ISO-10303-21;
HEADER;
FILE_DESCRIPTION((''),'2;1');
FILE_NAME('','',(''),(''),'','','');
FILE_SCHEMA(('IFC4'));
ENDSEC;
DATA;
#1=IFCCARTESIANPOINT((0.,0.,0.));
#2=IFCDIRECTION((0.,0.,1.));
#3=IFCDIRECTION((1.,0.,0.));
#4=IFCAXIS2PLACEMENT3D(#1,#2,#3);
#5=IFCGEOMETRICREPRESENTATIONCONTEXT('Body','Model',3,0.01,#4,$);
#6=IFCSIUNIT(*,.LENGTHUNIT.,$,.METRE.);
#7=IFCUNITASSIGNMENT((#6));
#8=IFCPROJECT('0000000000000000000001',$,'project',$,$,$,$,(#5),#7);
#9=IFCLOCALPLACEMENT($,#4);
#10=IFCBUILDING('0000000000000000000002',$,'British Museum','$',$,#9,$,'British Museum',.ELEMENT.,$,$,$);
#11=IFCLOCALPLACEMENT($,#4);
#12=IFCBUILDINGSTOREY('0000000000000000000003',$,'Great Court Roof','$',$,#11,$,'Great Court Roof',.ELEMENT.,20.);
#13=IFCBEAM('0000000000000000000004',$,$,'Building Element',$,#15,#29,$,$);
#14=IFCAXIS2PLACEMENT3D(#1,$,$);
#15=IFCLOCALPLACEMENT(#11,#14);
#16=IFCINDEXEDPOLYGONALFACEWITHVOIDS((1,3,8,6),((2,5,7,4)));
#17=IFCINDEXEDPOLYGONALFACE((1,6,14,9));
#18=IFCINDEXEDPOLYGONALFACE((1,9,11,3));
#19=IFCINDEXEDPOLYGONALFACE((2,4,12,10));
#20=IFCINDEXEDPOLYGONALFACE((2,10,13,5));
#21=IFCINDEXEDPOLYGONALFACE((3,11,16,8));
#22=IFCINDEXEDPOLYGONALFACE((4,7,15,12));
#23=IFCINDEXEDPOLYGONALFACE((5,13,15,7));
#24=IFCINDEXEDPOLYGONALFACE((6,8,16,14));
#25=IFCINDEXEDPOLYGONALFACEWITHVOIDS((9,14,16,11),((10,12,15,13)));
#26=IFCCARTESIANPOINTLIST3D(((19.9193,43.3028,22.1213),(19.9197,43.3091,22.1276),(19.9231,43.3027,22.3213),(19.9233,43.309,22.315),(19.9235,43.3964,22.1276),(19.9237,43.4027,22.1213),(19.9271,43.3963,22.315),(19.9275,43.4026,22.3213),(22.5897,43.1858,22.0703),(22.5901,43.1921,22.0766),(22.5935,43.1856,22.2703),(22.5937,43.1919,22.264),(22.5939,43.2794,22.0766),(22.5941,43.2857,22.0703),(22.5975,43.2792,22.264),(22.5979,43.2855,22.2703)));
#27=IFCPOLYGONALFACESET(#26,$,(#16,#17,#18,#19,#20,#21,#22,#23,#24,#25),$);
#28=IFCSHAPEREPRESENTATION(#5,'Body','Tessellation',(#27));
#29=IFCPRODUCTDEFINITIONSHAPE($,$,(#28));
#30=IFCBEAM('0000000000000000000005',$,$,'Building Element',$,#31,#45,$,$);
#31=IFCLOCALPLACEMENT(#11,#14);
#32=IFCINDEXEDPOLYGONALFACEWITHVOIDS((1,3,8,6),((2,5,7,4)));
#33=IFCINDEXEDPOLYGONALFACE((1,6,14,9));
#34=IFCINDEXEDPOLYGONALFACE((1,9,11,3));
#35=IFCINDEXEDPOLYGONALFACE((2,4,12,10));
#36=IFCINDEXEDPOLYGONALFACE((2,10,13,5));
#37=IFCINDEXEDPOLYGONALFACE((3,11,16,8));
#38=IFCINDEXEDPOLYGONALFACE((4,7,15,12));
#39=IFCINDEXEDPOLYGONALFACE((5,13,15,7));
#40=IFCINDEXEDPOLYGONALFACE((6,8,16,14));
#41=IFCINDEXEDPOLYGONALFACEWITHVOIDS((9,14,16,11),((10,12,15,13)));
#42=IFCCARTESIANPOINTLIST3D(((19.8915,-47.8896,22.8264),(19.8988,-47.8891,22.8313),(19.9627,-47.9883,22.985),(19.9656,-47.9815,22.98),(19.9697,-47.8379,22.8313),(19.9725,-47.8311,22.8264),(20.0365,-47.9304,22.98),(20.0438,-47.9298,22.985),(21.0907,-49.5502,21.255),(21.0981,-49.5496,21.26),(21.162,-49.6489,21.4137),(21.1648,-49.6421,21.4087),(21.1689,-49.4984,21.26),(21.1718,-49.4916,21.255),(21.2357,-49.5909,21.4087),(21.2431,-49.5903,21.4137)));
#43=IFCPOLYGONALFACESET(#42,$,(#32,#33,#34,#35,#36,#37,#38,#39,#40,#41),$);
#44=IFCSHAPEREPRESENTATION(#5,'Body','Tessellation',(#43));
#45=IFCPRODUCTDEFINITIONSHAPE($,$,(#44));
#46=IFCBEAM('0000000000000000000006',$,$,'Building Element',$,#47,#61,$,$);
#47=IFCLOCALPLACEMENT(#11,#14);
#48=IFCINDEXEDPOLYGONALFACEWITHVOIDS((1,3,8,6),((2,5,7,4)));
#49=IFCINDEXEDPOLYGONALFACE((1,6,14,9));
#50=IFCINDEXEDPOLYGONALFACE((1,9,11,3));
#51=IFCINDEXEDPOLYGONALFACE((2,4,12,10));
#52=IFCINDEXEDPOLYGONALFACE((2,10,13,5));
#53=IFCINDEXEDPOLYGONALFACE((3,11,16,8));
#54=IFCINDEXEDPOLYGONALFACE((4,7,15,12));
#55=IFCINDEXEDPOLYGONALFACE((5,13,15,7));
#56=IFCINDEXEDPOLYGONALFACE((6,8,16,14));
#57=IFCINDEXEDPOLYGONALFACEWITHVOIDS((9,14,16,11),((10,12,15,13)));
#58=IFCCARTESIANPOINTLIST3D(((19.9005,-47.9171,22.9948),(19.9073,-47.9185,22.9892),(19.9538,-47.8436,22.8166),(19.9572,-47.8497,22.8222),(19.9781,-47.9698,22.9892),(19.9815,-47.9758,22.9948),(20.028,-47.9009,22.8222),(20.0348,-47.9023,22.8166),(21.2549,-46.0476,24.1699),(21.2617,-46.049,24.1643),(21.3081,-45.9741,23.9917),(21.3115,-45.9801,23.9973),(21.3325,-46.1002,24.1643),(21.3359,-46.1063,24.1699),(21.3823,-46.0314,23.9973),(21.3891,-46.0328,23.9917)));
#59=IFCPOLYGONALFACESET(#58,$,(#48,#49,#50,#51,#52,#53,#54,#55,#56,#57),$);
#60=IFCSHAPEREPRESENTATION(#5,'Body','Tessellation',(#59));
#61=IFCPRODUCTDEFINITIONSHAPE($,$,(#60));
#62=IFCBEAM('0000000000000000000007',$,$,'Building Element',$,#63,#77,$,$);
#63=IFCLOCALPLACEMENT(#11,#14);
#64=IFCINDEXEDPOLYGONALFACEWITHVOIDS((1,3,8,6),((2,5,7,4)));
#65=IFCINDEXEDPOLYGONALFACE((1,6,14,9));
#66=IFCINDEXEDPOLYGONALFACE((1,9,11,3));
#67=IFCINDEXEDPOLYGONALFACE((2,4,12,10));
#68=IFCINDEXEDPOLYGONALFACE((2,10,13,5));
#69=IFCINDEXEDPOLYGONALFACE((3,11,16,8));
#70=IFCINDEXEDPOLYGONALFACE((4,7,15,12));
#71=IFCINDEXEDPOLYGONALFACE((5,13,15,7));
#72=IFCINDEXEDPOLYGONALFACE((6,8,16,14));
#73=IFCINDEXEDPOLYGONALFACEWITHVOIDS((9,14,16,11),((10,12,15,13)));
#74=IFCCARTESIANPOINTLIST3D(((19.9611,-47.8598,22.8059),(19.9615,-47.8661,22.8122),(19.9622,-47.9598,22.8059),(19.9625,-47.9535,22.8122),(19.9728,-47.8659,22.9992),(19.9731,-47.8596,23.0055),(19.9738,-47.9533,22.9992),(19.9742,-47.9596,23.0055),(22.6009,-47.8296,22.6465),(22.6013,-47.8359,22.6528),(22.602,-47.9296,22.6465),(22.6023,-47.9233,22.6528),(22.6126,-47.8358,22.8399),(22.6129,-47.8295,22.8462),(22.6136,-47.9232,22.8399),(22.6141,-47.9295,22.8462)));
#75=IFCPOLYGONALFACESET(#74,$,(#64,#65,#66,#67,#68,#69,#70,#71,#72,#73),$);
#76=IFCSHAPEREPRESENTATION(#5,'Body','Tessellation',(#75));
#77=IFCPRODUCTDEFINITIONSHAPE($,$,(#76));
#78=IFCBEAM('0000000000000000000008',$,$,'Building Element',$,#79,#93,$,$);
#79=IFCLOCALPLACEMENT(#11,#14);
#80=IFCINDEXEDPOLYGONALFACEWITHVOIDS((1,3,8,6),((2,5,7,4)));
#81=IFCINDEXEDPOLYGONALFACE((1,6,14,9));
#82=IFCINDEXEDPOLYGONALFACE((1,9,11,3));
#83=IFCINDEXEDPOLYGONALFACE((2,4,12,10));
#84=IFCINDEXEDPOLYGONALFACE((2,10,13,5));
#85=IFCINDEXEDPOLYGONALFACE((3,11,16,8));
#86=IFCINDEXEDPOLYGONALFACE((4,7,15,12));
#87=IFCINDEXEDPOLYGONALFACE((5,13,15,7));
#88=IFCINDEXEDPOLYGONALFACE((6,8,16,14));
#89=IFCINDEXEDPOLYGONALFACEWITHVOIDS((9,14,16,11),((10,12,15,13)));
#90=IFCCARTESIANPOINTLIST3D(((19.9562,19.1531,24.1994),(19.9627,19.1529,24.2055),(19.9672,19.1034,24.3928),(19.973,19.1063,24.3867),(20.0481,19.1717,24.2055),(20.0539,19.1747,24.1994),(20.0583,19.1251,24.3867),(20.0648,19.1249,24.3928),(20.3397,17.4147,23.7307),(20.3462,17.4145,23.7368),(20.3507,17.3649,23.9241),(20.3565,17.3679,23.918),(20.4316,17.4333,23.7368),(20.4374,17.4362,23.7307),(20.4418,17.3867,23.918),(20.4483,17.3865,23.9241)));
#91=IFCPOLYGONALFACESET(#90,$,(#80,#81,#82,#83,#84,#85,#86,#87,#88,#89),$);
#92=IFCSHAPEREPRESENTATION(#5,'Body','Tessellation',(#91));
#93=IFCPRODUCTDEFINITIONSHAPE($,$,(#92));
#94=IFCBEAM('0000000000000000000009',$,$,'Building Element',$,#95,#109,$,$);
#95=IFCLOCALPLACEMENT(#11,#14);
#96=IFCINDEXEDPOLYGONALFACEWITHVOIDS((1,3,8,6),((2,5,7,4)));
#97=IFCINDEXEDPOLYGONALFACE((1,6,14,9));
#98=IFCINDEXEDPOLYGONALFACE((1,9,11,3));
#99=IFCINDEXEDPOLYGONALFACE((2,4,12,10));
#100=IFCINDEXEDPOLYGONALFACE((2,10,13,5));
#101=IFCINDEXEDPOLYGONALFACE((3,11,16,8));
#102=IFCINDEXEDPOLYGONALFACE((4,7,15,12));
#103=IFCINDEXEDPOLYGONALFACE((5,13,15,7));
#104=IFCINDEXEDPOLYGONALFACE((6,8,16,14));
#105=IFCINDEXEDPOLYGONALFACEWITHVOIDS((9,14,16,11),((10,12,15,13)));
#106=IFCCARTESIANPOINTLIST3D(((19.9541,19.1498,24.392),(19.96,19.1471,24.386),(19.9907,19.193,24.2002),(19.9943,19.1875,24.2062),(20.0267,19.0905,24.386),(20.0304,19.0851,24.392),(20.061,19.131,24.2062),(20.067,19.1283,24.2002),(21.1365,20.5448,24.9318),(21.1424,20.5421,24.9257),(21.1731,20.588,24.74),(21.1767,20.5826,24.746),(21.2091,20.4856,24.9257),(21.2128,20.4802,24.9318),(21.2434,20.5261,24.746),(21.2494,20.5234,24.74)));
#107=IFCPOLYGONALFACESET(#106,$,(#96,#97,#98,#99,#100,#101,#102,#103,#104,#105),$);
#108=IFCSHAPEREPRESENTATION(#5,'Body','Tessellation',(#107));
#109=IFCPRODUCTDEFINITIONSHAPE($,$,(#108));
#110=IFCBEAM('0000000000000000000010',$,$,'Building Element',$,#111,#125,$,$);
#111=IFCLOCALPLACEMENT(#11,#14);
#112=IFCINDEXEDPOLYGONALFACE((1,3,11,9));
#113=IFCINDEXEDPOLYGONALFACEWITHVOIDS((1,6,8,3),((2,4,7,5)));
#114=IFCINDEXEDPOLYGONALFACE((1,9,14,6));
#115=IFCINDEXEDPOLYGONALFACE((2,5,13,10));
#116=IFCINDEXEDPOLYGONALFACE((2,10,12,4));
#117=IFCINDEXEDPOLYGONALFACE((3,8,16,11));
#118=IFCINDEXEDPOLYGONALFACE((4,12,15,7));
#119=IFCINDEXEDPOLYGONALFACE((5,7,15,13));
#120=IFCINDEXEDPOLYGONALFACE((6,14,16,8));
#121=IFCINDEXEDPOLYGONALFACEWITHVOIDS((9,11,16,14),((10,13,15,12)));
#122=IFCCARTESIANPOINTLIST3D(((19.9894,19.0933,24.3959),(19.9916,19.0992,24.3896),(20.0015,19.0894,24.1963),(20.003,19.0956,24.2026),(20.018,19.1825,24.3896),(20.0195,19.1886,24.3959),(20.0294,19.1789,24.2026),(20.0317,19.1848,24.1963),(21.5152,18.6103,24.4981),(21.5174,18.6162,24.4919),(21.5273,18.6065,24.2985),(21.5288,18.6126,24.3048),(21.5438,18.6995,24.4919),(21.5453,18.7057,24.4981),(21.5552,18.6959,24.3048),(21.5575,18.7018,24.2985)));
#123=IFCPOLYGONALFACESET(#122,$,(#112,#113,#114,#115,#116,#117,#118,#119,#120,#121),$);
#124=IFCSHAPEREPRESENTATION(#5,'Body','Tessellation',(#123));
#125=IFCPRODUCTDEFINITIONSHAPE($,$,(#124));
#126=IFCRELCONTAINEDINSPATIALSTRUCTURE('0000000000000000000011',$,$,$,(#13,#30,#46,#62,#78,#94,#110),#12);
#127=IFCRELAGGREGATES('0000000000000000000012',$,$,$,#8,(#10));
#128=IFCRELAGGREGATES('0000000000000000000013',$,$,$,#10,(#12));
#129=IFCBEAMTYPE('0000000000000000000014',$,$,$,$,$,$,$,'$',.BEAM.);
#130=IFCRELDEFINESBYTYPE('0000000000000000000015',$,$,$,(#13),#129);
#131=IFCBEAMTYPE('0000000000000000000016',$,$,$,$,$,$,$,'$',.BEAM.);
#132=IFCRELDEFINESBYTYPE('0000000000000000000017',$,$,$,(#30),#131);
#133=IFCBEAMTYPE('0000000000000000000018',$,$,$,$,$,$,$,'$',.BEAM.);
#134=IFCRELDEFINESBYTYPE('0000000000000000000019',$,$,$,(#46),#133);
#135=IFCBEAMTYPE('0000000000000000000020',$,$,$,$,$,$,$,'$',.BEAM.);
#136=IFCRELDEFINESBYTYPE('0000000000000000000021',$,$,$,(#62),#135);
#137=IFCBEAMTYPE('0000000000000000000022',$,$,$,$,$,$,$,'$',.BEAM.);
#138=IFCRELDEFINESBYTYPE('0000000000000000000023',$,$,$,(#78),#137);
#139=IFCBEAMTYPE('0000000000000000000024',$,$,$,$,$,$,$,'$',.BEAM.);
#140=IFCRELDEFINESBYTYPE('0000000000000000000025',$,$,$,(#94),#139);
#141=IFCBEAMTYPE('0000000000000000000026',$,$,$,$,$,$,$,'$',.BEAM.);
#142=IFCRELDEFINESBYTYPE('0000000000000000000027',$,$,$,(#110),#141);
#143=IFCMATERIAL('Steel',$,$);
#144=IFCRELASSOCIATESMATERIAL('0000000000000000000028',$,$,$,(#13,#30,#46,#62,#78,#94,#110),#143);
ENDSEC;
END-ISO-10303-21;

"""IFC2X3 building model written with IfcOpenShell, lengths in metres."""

from ifc_helpers import new_model, si_unit, frame, origin_with_axes, origin_2d, place, context, project, spatial, hollow_rectangle, extrude, material, type_object, element, save


model = new_model("IFC2X3")

# Units and contexts
model_context = context("Model", 3, precision=0.01, world=origin_with_axes(), identifier="Body")
ifc_project = project(units=[si_unit("LENGTHUNIT", "METRE")], contexts=[model_context])

# Building, storey
building_placement = place(None, origin_with_axes())
building = spatial("IfcBuilding", under=ifc_project, at=building_placement, Name="British Museum", Description="$", LongName="British Museum", CompositionType="ELEMENT")
storey_placement = place(None, origin_with_axes())
storey = spatial("IfcBuildingStorey", under=building, at=storey_placement, Name="Great Court Roof", Description="$", LongName="Great Court Roof", CompositionType="ELEMENT", Elevation=20.0)

# Beams
ifc_material = material(Name="Steel")
beam_type_1 = type_object("IfcBeamType", ElementType="$", PredefinedType="BEAM")
beam_1_placement = place(None, origin_with_axes())
element("IfcBeam", 1, at=beam_1_placement, inside=storey, type_object=beam_type_1, material=ifc_material, Description="Building Element", context=model_context, shape_type="SweptSolid", body=[
    extrude(hollow_rectangle(XDim=0.1, YDim=0.2, WallThickness=0.0063, InnerFilletRadius=-0.0063, OuterFilletRadius=0.0, at=origin_2d()), frame((19.9234, 43.3527, 22.2213), z_axis=(0.998859, -0.043783, -0.019081), x_axis=(0.043791, 0.999041, 0.0)), (0.0, 0.0, 1.0), 2.6735),
])
beam_type_2 = type_object("IfcBeamType", ElementType="$", PredefinedType="BEAM")
beam_2_placement = place(None, origin_with_axes())
element("IfcBeam", 2, at=beam_2_placement, inside=storey, type_object=beam_type_2, material=ifc_material, Description="Building Element", context=model_context, shape_type="SweptSolid", body=[
    extrude(hollow_rectangle(XDim=0.1, YDim=0.2, WallThickness=0.0063, InnerFilletRadius=-0.0063, OuterFilletRadius=0.0, at=origin_2d()), frame((19.9676, -47.9097, 22.9057), z_axis=(0.464529, -0.643211, -0.608681), x_axis=(0.810687, 0.58548, 0.0)), (0.0, 0.0, 1.0), 2.5816),
])
beam_type_3 = type_object("IfcBeamType", ElementType="$", PredefinedType="BEAM")
beam_3_placement = place(None, origin_with_axes())
element("IfcBeam", 3, at=beam_3_placement, inside=storey, type_object=beam_type_3, material=ifc_material, Description="Building Element", context=model_context, shape_type="SweptSolid", body=[
    extrude(hollow_rectangle(XDim=0.1, YDim=0.2, WallThickness=0.0063, InnerFilletRadius=-0.0063, OuterFilletRadius=0.0, at=origin_2d()), frame((19.9676, -47.9097, 22.9057), z_axis=(0.522834, 0.721709, 0.45363), x_axis=(-0.809826, 0.58667, 0.0)), (0.0, 0.0, 1.0), 2.5904),
])
beam_type_4 = type_object("IfcBeamType", ElementType="$", PredefinedType="BEAM")
beam_4_placement = place(None, origin_with_axes())
element("IfcBeam", 4, at=beam_4_placement, inside=storey, type_object=beam_type_4, material=ifc_material, Description="Building Element", context=model_context, shape_type="SweptSolid", body=[
    extrude(hollow_rectangle(XDim=0.1, YDim=0.2, WallThickness=0.0063, InnerFilletRadius=-0.0063, OuterFilletRadius=0.0, at=origin_2d()), frame((19.9676, -47.9097, 22.9057), z_axis=(0.998118, 0.011408, -0.060249), x_axis=(-0.011428, 0.999935, 0.0)), (0.0, 0.0, 1.0), 2.6448),
])
beam_type_5 = type_object("IfcBeamType", ElementType="$", PredefinedType="BEAM")
beam_5_placement = place(None, origin_with_axes())
element("IfcBeam", 5, at=beam_5_placement, inside=storey, type_object=beam_type_5, material=ifc_material, Description="Building Element", context=model_context, shape_type="SweptSolid", body=[
    extrude(hollow_rectangle(XDim=0.1, YDim=0.2, WallThickness=0.0063, InnerFilletRadius=-0.0063, OuterFilletRadius=0.0, at=origin_2d()), frame((20.0105, 19.139, 24.2961), z_axis=(0.208317, -0.944341, -0.254607), x_axis=(0.976522, 0.215416, 0.0)), (0.0, 0.0, 1.0), 1.8409),
])
beam_type_6 = type_object("IfcBeamType", ElementType="$", PredefinedType="BEAM")
beam_6_placement = place(None, origin_with_axes())
element("IfcBeam", 6, at=beam_6_placement, inside=storey, type_object=beam_type_6, material=ifc_material, Description="Building Element", context=model_context, shape_type="SweptSolid", body=[
    extrude(hollow_rectangle(XDim=0.1, YDim=0.2, WallThickness=0.0063, InnerFilletRadius=-0.0063, OuterFilletRadius=0.0, at=origin_2d()), frame((20.0105, 19.139, 24.2961), z_axis=(0.620116, 0.731653, 0.283091), x_axis=(-0.762859, 0.646565, 0.0)), (0.0, 0.0, 1.0), 1.9067),
])
beam_type_7 = type_object("IfcBeamType", ElementType="$", PredefinedType="BEAM")
beam_7_placement = place(None, origin_with_axes())
element("IfcBeam", 7, at=beam_7_placement, inside=storey, type_object=beam_type_7, material=ifc_material, Description="Building Element", context=model_context, shape_type="SweptSolid", body=[
    extrude(hollow_rectangle(XDim=0.1, YDim=0.2, WallThickness=0.0063, InnerFilletRadius=-0.0063, OuterFilletRadius=0.0, at=origin_2d()), frame((20.0105, 19.139, 24.2961), z_axis=(0.951441, -0.301158, 0.063754), x_axis=(0.301772, 0.95338, 0.0)), (0.0, 0.0, 1.0), 1.6037),
])

save(model, "model.ifc")
